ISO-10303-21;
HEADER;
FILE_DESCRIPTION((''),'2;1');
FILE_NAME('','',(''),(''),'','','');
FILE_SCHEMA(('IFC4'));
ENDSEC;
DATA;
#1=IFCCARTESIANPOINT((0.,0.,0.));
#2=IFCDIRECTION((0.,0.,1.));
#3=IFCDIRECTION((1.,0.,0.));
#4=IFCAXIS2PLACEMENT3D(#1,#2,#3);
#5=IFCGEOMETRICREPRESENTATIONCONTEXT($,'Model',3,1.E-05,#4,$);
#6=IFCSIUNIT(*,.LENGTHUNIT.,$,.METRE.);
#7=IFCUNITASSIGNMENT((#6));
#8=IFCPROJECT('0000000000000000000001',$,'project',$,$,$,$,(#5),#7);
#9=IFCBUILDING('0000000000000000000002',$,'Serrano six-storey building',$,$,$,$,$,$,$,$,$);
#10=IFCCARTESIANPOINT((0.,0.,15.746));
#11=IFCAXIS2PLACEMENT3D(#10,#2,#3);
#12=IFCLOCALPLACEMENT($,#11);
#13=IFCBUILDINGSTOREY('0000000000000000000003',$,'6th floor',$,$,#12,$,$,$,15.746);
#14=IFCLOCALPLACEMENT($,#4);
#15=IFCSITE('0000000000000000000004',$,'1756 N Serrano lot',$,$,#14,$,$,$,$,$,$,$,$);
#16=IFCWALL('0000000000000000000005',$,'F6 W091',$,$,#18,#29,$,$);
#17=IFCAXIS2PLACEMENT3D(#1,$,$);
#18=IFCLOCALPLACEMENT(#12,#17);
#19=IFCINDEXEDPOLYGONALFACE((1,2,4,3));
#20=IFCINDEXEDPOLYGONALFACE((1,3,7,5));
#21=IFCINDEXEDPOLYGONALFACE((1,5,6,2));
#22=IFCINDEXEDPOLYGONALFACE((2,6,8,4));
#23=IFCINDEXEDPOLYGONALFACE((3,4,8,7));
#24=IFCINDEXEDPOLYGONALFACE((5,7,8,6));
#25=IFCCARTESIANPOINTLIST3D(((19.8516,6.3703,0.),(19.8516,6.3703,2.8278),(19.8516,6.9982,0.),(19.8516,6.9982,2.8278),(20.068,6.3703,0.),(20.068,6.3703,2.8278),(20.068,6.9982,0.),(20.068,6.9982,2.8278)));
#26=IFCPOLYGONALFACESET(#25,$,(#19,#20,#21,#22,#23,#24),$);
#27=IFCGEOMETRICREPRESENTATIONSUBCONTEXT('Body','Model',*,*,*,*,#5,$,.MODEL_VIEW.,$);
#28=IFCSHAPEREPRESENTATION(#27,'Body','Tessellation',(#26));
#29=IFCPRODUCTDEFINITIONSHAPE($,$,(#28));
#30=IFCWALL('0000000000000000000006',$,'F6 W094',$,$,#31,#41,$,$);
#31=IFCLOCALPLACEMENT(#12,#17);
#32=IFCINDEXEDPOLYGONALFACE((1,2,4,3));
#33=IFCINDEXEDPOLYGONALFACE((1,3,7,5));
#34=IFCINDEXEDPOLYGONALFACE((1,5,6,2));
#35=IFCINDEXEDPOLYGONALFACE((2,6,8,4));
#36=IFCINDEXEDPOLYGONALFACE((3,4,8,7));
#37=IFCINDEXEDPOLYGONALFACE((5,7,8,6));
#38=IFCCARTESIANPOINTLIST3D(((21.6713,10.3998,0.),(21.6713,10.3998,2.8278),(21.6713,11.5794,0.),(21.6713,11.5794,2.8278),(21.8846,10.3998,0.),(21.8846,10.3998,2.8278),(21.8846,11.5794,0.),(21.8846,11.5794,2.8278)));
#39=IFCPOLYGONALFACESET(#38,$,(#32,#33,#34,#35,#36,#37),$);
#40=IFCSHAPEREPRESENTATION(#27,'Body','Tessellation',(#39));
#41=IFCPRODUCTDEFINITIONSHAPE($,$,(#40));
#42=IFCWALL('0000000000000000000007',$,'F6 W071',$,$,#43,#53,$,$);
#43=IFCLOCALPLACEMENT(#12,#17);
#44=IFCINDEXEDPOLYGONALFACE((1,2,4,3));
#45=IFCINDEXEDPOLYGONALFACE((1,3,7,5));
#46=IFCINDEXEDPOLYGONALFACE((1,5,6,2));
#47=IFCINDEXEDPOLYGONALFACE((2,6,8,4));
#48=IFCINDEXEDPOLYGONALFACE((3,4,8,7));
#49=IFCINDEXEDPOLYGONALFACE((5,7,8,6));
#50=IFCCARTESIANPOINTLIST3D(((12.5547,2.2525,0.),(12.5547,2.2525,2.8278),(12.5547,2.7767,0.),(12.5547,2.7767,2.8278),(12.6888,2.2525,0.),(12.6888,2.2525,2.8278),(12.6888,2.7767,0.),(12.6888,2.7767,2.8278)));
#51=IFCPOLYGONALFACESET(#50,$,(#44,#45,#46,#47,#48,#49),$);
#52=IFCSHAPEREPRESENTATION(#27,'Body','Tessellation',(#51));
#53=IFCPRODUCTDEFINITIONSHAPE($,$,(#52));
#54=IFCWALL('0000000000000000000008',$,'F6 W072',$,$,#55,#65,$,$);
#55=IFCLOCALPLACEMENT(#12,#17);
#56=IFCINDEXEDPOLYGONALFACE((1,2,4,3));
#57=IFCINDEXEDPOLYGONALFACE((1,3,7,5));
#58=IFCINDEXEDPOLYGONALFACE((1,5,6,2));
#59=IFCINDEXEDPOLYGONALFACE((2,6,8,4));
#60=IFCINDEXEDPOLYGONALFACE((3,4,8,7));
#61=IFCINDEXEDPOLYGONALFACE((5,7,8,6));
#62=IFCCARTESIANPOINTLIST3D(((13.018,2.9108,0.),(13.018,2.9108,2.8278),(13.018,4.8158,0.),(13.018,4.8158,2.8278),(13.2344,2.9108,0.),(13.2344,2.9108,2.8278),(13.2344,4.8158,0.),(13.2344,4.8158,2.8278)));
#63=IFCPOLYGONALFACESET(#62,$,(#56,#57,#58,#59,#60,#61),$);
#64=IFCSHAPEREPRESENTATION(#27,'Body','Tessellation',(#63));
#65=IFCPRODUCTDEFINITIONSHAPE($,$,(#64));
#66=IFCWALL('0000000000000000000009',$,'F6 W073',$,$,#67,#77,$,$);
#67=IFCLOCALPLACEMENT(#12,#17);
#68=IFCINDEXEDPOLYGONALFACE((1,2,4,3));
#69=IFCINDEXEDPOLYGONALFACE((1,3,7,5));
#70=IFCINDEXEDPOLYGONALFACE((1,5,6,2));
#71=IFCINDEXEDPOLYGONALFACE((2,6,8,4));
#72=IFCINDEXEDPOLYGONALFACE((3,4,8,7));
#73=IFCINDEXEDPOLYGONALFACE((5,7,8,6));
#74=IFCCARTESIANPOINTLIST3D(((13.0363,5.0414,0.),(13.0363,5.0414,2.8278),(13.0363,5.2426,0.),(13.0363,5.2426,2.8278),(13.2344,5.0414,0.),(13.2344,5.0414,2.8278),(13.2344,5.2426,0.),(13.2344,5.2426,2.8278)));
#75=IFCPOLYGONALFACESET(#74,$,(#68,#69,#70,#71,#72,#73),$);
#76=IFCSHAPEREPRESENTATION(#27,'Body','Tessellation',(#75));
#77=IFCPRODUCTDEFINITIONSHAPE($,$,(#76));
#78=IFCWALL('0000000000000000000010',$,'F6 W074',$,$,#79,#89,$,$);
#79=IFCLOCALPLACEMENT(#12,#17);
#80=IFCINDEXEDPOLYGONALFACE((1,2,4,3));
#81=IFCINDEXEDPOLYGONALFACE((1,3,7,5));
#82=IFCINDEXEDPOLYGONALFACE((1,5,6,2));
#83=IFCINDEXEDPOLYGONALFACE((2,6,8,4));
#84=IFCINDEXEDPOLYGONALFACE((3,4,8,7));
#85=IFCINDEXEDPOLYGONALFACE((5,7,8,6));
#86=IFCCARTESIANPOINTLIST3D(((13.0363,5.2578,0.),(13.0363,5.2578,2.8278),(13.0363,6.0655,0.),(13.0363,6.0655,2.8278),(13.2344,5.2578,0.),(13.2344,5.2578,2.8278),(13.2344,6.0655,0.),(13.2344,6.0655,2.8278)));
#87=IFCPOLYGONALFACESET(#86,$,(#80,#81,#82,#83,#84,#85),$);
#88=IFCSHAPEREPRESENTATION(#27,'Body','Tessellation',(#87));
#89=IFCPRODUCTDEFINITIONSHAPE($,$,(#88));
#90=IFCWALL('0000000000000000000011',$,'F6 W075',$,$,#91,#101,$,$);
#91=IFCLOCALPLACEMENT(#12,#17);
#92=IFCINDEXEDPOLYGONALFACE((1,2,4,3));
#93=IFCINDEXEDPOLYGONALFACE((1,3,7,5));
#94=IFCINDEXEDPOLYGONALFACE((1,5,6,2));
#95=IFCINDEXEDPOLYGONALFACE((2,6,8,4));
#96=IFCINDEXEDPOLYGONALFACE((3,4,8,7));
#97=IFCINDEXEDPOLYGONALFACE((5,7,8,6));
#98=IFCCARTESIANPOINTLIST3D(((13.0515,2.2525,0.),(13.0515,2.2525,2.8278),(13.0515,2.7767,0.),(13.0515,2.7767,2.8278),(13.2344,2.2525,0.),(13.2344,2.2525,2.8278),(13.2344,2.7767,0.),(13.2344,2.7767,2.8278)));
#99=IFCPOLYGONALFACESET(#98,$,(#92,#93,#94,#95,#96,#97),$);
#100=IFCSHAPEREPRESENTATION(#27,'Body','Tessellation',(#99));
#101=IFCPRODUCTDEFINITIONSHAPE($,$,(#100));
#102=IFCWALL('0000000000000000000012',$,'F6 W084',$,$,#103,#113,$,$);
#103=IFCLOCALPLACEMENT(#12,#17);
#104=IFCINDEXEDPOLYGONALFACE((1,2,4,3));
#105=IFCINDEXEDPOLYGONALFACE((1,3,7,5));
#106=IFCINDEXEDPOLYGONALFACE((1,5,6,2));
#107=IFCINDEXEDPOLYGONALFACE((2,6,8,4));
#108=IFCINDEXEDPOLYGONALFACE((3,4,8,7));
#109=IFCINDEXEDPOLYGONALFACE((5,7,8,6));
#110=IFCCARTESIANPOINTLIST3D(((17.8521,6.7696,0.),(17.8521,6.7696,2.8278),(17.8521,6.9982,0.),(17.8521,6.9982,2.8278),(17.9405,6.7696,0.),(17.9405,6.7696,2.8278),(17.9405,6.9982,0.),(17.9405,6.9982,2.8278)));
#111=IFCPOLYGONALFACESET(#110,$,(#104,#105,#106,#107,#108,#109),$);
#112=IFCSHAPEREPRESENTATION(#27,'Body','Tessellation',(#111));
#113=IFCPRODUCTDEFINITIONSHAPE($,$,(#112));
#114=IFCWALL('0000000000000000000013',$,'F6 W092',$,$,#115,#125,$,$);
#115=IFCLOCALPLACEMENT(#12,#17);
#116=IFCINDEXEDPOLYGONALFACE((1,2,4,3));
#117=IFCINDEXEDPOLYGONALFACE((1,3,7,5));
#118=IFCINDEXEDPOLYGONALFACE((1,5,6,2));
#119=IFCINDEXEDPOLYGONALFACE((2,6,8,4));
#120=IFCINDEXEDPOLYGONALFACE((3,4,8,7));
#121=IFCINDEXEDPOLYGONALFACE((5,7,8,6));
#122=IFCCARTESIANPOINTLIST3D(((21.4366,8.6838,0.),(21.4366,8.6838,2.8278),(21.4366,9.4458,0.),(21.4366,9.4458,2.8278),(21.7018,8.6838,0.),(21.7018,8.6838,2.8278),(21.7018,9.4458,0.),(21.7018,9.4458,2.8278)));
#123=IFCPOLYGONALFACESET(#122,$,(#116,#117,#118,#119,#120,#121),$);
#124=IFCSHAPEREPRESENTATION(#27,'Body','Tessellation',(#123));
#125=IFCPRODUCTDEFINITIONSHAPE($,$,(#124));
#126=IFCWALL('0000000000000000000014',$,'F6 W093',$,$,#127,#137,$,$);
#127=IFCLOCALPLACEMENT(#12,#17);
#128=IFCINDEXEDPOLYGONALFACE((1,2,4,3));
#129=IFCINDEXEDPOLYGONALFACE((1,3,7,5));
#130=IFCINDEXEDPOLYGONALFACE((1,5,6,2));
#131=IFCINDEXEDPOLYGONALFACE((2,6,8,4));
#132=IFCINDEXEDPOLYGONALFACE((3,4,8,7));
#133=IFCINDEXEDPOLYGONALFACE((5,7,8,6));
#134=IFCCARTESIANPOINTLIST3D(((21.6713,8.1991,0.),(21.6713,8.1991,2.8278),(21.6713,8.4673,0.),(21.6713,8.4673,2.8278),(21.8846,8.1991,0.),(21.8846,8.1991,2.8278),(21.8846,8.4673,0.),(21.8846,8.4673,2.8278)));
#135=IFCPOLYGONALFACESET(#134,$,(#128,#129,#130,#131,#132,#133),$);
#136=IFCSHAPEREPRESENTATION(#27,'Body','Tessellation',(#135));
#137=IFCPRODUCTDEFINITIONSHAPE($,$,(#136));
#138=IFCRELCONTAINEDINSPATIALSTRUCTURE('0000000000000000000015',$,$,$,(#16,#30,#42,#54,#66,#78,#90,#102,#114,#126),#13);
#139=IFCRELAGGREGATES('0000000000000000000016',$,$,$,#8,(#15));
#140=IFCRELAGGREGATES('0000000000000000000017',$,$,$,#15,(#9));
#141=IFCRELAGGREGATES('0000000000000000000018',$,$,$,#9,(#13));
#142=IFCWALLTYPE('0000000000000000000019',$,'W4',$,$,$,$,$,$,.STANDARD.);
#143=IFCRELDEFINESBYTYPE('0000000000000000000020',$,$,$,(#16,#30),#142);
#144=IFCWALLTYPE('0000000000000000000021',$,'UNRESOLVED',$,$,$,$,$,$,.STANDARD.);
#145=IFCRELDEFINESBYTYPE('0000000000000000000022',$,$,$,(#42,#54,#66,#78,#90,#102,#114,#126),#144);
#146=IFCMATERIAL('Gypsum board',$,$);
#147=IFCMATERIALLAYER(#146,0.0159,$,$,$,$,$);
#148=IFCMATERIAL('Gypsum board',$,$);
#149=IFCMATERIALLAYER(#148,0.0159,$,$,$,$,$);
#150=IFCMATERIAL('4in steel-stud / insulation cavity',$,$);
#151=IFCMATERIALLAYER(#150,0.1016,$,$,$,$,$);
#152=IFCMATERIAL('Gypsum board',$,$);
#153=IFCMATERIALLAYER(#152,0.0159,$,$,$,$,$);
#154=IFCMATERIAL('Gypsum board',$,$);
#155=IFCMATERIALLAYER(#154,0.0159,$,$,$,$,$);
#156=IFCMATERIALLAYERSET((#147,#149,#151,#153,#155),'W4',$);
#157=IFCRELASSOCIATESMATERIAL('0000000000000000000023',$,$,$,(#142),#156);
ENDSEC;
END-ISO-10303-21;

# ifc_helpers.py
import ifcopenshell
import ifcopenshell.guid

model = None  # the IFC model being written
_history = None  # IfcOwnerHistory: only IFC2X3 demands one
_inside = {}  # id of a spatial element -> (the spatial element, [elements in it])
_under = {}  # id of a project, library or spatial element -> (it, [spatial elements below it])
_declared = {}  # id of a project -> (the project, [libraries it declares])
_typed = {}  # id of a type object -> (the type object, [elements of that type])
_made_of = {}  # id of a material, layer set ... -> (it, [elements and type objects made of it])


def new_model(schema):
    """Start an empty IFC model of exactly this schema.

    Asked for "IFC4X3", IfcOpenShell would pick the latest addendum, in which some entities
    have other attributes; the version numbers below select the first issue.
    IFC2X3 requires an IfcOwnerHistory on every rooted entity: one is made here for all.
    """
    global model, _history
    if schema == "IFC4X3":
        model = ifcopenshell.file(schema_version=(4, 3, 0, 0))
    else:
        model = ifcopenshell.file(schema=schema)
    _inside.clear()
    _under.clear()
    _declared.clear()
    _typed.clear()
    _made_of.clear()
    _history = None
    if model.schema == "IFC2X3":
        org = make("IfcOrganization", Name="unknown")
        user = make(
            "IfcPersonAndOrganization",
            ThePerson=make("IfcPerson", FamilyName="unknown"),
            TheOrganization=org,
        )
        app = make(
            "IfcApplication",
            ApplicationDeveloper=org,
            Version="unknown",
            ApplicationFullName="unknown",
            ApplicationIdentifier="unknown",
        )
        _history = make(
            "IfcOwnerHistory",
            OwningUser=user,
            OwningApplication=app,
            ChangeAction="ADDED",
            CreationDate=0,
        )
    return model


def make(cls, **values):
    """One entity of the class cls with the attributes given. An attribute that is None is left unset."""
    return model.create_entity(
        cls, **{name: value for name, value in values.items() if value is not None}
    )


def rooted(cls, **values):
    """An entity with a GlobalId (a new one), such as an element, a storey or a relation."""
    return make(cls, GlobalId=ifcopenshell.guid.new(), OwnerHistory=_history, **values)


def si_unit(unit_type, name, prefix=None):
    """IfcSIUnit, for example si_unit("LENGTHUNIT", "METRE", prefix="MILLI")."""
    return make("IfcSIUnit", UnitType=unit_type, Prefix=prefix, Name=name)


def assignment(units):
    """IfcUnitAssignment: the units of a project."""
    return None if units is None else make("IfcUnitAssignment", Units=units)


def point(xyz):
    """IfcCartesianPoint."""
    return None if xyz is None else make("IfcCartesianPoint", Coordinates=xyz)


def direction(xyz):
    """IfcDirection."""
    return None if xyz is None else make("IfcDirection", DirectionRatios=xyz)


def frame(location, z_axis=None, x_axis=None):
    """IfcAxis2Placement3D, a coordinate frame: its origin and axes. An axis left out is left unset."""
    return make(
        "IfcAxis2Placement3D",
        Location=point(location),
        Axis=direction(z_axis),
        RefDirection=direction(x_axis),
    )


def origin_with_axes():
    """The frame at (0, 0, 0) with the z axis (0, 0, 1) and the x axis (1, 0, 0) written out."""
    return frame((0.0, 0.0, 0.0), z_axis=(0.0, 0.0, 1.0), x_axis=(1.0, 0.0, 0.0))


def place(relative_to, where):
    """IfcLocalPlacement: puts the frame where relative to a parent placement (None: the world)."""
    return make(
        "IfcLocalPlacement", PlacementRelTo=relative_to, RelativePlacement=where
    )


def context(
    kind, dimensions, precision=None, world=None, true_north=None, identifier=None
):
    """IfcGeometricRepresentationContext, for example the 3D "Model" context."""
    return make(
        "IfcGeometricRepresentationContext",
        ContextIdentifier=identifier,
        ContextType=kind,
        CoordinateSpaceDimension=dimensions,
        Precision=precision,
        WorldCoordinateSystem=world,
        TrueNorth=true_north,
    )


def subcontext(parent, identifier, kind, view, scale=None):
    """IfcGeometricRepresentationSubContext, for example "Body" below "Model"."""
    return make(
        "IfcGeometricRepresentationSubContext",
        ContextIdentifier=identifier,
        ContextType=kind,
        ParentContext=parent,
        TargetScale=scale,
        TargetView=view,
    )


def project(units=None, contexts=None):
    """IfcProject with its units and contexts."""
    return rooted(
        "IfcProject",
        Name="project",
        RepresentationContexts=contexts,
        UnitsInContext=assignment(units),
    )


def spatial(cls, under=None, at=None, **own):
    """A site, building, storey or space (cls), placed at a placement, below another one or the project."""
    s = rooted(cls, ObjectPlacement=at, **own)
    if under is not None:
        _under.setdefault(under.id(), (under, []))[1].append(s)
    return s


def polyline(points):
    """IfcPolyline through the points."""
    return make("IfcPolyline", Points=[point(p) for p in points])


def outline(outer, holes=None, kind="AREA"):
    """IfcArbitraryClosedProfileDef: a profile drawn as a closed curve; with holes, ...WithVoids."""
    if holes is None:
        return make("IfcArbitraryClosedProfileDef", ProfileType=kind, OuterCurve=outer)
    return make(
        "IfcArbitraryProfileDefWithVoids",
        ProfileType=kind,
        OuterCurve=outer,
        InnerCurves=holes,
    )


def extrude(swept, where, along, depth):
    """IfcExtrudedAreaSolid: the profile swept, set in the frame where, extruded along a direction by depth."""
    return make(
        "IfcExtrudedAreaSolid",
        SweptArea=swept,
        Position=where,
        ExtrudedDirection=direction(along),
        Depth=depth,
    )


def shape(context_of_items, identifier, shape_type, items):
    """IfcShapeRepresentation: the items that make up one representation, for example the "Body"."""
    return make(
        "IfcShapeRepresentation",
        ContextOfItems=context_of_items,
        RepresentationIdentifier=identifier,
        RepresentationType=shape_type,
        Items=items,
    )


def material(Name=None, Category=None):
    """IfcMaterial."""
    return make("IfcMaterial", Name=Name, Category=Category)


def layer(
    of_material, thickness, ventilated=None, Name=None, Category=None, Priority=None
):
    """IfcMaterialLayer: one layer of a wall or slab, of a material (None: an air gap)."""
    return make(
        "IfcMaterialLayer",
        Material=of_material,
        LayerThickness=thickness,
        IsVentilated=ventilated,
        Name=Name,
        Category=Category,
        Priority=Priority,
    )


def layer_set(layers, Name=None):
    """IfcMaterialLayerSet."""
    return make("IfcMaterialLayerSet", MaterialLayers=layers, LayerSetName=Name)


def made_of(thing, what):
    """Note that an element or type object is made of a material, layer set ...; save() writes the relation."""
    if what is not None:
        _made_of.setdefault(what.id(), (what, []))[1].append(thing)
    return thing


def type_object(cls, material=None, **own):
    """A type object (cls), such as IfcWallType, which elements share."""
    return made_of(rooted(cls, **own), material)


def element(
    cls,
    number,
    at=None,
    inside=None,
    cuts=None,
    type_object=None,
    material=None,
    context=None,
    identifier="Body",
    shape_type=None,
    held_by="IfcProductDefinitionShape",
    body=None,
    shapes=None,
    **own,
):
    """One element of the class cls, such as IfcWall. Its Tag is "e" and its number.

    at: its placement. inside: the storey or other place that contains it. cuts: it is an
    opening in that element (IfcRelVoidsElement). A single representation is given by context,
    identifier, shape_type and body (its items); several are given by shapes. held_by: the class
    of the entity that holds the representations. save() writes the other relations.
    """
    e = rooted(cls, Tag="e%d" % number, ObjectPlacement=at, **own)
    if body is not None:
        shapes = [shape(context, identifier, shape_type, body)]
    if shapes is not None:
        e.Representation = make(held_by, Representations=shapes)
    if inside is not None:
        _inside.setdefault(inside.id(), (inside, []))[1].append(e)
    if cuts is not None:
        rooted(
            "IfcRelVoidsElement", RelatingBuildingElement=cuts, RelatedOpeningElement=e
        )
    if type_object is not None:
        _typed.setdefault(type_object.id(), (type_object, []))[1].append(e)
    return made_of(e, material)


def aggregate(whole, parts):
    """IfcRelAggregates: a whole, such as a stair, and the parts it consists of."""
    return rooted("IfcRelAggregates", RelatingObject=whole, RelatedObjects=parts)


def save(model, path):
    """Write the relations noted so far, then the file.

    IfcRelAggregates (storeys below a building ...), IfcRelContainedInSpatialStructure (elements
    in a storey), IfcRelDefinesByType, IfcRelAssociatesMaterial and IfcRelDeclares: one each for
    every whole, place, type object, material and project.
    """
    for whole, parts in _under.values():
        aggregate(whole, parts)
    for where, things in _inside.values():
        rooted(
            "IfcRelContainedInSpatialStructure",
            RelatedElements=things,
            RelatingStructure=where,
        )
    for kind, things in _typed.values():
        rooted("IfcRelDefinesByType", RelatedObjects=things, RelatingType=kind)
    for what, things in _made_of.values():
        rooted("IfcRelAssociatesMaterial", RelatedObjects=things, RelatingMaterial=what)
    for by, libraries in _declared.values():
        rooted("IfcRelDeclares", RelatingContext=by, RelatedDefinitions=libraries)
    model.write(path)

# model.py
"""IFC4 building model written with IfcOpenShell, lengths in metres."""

from ifc_helpers import new_model, si_unit, frame, origin_with_axes, place, context, subcontext, project, spatial, polyline, outline, extrude, material, layer, layer_set, type_object, element, save


model = new_model("IFC4")

# Units and contexts
model_context = context("Model", 3, precision=1e-05, world=origin_with_axes())
body_context = subcontext(model_context, "Body", "Model", "MODEL_VIEW")
ifc_project = project(units=[si_unit("LENGTHUNIT", "METRE")], contexts=[model_context])

# Site, building, storey
site_placement = place(None, origin_with_axes())
site = spatial("IfcSite", under=ifc_project, at=site_placement, Name="1756 N Serrano lot")
building = spatial("IfcBuilding", under=site, Name="Serrano six-storey building")
storey_placement = place(None, frame((0.0, 0.0, 15.746), z_axis=(0.0, 0.0, 1.0), x_axis=(1.0, 0.0, 0.0)))
storey = spatial("IfcBuildingStorey", under=building, at=storey_placement, Name="6th floor", Elevation=15.746)

# Walls
ifc_material_1 = material(Name="Gypsum board")
ifc_layer_1 = layer(ifc_material_1, 0.0159)
ifc_material_2 = material(Name="Gypsum board")
ifc_layer_2 = layer(ifc_material_2, 0.0159)
ifc_material_3 = material(Name="4in steel-stud / insulation cavity")
ifc_layer_3 = layer(ifc_material_3, 0.1016)
ifc_material_4 = material(Name="Gypsum board")
ifc_layer_4 = layer(ifc_material_4, 0.0159)
ifc_material_5 = material(Name="Gypsum board")
ifc_layer_5 = layer(ifc_material_5, 0.0159)
ifc_layer_set_1 = layer_set([ifc_layer_1, ifc_layer_2, ifc_layer_3, ifc_layer_4, ifc_layer_5], Name="W4")
wall_type_1 = type_object("IfcWallType", Name="W4", PredefinedType="STANDARD", material=ifc_layer_set_1)
wall_1_placement = place(storey_placement, frame((0.0, 0.0, -15.746), z_axis=(0.0, 0.0, 1.0), x_axis=(1.0, 0.0, 0.0)))
element("IfcWall", 1, at=wall_1_placement, inside=storey, type_object=wall_type_1, Name="F6 W091", context=body_context, shape_type="SweptSolid", body=[
    extrude(outline(polyline([(19.8516, 6.9982), (20.068, 6.9982), (20.068, 6.3703), (19.8516, 6.3703), (19.8516, 6.9982)])), frame((0.0, 0.0, 15.746)), (0.0, 0.0, 1.0), 2.8278),
])
wall_2_placement = place(storey_placement, frame((0.0, 0.0, -15.746), z_axis=(0.0, 0.0, 1.0), x_axis=(1.0, 0.0, 0.0)))
element("IfcWall", 2, at=wall_2_placement, inside=storey, type_object=wall_type_1, Name="F6 W094", context=body_context, shape_type="SweptSolid", body=[
    extrude(outline(polyline([(21.6713, 11.5794), (21.8846, 11.5794), (21.8846, 10.3998), (21.6713, 10.3998), (21.6713, 11.5794)])), frame((0.0, 0.0, 15.746)), (0.0, 0.0, 1.0), 2.8278),
])
wall_type_2 = type_object("IfcWallType", Name="UNRESOLVED", PredefinedType="STANDARD")
wall_3_placement = place(storey_placement, frame((0.0, 0.0, -15.746), z_axis=(0.0, 0.0, 1.0), x_axis=(1.0, 0.0, 0.0)))
element("IfcWall", 3, at=wall_3_placement, inside=storey, type_object=wall_type_2, Name="F6 W071", context=body_context, shape_type="SweptSolid", body=[
    extrude(outline(polyline([(12.5547, 2.7767), (12.6888, 2.7767), (12.6888, 2.2525), (12.5547, 2.2525), (12.5547, 2.7767)])), frame((0.0, 0.0, 15.746)), (0.0, 0.0, 1.0), 2.8278),
])
wall_4_placement = place(storey_placement, frame((0.0, 0.0, -15.746), z_axis=(0.0, 0.0, 1.0), x_axis=(1.0, 0.0, 0.0)))
element("IfcWall", 4, at=wall_4_placement, inside=storey, type_object=wall_type_2, Name="F6 W072", context=body_context, shape_type="SweptSolid", body=[
    extrude(outline(polyline([(13.018, 4.8158), (13.2344, 4.8158), (13.2344, 2.9108), (13.018, 2.9108), (13.018, 4.8158)])), frame((0.0, 0.0, 15.746)), (0.0, 0.0, 1.0), 2.8278),
])
wall_5_placement = place(storey_placement, frame((0.0, 0.0, -15.746), z_axis=(0.0, 0.0, 1.0), x_axis=(1.0, 0.0, 0.0)))
element("IfcWall", 5, at=wall_5_placement, inside=storey, type_object=wall_type_2, Name="F6 W073", context=body_context, shape_type="SweptSolid", body=[
    extrude(outline(polyline([(13.0363, 5.2426), (13.2344, 5.2426), (13.2344, 5.0414), (13.0363, 5.0414), (13.0363, 5.2426)])), frame((0.0, 0.0, 15.746)), (0.0, 0.0, 1.0), 2.8278),
])
wall_6_placement = place(storey_placement, frame((0.0, 0.0, -15.746), z_axis=(0.0, 0.0, 1.0), x_axis=(1.0, 0.0, 0.0)))
element("IfcWall", 6, at=wall_6_placement, inside=storey, type_object=wall_type_2, Name="F6 W074", context=body_context, shape_type="SweptSolid", body=[
    extrude(outline(polyline([(13.0363, 6.0655), (13.2344, 6.0655), (13.2344, 5.2578), (13.0363, 5.2578), (13.0363, 6.0655)])), frame((0.0, 0.0, 15.746)), (0.0, 0.0, 1.0), 2.8278),
])
wall_7_placement = place(storey_placement, frame((0.0, 0.0, -15.746), z_axis=(0.0, 0.0, 1.0), x_axis=(1.0, 0.0, 0.0)))
element("IfcWall", 7, at=wall_7_placement, inside=storey, type_object=wall_type_2, Name="F6 W075", context=body_context, shape_type="SweptSolid", body=[
    extrude(outline(polyline([(13.0515, 2.7767), (13.2344, 2.7767), (13.2344, 2.2525), (13.0515, 2.2525), (13.0515, 2.7767)])), frame((0.0, 0.0, 15.746)), (0.0, 0.0, 1.0), 2.8278),
])
wall_8_placement = place(storey_placement, frame((0.0, 0.0, -15.746), z_axis=(0.0, 0.0, 1.0), x_axis=(1.0, 0.0, 0.0)))
element("IfcWall", 8, at=wall_8_placement, inside=storey, type_object=wall_type_2, Name="F6 W084", context=body_context, shape_type="SweptSolid", body=[
    extrude(outline(polyline([(17.8521, 6.9982), (17.9405, 6.9982), (17.9405, 6.7696), (17.8521, 6.7696), (17.8521, 6.9982)])), frame((0.0, 0.0, 15.746)), (0.0, 0.0, 1.0), 2.8278),
])
wall_9_placement = place(storey_placement, frame((0.0, 0.0, -15.746), z_axis=(0.0, 0.0, 1.0), x_axis=(1.0, 0.0, 0.0)))
element("IfcWall", 9, at=wall_9_placement, inside=storey, type_object=wall_type_2, Name="F6 W092", context=body_context, shape_type="SweptSolid", body=[
    extrude(outline(polyline([(21.4366, 9.4458), (21.7018, 9.4458), (21.7018, 8.6838), (21.4366, 8.6838), (21.4366, 9.4458)])), frame((0.0, 0.0, 15.746)), (0.0, 0.0, 1.0), 2.8278),
])
wall_10_placement = place(storey_placement, frame((0.0, 0.0, -15.746), z_axis=(0.0, 0.0, 1.0), x_axis=(1.0, 0.0, 0.0)))
element("IfcWall", 10, at=wall_10_placement, inside=storey, type_object=wall_type_2, Name="F6 W093", context=body_context, shape_type="SweptSolid", body=[
    extrude(outline(polyline([(21.6713, 8.4673), (21.8846, 8.4673), (21.8846, 8.1991), (21.6713, 8.1991), (21.6713, 8.4673)])), frame((0.0, 0.0, 15.746)), (0.0, 0.0, 1.0), 2.8278),
])

save(model, "model.ifc")
